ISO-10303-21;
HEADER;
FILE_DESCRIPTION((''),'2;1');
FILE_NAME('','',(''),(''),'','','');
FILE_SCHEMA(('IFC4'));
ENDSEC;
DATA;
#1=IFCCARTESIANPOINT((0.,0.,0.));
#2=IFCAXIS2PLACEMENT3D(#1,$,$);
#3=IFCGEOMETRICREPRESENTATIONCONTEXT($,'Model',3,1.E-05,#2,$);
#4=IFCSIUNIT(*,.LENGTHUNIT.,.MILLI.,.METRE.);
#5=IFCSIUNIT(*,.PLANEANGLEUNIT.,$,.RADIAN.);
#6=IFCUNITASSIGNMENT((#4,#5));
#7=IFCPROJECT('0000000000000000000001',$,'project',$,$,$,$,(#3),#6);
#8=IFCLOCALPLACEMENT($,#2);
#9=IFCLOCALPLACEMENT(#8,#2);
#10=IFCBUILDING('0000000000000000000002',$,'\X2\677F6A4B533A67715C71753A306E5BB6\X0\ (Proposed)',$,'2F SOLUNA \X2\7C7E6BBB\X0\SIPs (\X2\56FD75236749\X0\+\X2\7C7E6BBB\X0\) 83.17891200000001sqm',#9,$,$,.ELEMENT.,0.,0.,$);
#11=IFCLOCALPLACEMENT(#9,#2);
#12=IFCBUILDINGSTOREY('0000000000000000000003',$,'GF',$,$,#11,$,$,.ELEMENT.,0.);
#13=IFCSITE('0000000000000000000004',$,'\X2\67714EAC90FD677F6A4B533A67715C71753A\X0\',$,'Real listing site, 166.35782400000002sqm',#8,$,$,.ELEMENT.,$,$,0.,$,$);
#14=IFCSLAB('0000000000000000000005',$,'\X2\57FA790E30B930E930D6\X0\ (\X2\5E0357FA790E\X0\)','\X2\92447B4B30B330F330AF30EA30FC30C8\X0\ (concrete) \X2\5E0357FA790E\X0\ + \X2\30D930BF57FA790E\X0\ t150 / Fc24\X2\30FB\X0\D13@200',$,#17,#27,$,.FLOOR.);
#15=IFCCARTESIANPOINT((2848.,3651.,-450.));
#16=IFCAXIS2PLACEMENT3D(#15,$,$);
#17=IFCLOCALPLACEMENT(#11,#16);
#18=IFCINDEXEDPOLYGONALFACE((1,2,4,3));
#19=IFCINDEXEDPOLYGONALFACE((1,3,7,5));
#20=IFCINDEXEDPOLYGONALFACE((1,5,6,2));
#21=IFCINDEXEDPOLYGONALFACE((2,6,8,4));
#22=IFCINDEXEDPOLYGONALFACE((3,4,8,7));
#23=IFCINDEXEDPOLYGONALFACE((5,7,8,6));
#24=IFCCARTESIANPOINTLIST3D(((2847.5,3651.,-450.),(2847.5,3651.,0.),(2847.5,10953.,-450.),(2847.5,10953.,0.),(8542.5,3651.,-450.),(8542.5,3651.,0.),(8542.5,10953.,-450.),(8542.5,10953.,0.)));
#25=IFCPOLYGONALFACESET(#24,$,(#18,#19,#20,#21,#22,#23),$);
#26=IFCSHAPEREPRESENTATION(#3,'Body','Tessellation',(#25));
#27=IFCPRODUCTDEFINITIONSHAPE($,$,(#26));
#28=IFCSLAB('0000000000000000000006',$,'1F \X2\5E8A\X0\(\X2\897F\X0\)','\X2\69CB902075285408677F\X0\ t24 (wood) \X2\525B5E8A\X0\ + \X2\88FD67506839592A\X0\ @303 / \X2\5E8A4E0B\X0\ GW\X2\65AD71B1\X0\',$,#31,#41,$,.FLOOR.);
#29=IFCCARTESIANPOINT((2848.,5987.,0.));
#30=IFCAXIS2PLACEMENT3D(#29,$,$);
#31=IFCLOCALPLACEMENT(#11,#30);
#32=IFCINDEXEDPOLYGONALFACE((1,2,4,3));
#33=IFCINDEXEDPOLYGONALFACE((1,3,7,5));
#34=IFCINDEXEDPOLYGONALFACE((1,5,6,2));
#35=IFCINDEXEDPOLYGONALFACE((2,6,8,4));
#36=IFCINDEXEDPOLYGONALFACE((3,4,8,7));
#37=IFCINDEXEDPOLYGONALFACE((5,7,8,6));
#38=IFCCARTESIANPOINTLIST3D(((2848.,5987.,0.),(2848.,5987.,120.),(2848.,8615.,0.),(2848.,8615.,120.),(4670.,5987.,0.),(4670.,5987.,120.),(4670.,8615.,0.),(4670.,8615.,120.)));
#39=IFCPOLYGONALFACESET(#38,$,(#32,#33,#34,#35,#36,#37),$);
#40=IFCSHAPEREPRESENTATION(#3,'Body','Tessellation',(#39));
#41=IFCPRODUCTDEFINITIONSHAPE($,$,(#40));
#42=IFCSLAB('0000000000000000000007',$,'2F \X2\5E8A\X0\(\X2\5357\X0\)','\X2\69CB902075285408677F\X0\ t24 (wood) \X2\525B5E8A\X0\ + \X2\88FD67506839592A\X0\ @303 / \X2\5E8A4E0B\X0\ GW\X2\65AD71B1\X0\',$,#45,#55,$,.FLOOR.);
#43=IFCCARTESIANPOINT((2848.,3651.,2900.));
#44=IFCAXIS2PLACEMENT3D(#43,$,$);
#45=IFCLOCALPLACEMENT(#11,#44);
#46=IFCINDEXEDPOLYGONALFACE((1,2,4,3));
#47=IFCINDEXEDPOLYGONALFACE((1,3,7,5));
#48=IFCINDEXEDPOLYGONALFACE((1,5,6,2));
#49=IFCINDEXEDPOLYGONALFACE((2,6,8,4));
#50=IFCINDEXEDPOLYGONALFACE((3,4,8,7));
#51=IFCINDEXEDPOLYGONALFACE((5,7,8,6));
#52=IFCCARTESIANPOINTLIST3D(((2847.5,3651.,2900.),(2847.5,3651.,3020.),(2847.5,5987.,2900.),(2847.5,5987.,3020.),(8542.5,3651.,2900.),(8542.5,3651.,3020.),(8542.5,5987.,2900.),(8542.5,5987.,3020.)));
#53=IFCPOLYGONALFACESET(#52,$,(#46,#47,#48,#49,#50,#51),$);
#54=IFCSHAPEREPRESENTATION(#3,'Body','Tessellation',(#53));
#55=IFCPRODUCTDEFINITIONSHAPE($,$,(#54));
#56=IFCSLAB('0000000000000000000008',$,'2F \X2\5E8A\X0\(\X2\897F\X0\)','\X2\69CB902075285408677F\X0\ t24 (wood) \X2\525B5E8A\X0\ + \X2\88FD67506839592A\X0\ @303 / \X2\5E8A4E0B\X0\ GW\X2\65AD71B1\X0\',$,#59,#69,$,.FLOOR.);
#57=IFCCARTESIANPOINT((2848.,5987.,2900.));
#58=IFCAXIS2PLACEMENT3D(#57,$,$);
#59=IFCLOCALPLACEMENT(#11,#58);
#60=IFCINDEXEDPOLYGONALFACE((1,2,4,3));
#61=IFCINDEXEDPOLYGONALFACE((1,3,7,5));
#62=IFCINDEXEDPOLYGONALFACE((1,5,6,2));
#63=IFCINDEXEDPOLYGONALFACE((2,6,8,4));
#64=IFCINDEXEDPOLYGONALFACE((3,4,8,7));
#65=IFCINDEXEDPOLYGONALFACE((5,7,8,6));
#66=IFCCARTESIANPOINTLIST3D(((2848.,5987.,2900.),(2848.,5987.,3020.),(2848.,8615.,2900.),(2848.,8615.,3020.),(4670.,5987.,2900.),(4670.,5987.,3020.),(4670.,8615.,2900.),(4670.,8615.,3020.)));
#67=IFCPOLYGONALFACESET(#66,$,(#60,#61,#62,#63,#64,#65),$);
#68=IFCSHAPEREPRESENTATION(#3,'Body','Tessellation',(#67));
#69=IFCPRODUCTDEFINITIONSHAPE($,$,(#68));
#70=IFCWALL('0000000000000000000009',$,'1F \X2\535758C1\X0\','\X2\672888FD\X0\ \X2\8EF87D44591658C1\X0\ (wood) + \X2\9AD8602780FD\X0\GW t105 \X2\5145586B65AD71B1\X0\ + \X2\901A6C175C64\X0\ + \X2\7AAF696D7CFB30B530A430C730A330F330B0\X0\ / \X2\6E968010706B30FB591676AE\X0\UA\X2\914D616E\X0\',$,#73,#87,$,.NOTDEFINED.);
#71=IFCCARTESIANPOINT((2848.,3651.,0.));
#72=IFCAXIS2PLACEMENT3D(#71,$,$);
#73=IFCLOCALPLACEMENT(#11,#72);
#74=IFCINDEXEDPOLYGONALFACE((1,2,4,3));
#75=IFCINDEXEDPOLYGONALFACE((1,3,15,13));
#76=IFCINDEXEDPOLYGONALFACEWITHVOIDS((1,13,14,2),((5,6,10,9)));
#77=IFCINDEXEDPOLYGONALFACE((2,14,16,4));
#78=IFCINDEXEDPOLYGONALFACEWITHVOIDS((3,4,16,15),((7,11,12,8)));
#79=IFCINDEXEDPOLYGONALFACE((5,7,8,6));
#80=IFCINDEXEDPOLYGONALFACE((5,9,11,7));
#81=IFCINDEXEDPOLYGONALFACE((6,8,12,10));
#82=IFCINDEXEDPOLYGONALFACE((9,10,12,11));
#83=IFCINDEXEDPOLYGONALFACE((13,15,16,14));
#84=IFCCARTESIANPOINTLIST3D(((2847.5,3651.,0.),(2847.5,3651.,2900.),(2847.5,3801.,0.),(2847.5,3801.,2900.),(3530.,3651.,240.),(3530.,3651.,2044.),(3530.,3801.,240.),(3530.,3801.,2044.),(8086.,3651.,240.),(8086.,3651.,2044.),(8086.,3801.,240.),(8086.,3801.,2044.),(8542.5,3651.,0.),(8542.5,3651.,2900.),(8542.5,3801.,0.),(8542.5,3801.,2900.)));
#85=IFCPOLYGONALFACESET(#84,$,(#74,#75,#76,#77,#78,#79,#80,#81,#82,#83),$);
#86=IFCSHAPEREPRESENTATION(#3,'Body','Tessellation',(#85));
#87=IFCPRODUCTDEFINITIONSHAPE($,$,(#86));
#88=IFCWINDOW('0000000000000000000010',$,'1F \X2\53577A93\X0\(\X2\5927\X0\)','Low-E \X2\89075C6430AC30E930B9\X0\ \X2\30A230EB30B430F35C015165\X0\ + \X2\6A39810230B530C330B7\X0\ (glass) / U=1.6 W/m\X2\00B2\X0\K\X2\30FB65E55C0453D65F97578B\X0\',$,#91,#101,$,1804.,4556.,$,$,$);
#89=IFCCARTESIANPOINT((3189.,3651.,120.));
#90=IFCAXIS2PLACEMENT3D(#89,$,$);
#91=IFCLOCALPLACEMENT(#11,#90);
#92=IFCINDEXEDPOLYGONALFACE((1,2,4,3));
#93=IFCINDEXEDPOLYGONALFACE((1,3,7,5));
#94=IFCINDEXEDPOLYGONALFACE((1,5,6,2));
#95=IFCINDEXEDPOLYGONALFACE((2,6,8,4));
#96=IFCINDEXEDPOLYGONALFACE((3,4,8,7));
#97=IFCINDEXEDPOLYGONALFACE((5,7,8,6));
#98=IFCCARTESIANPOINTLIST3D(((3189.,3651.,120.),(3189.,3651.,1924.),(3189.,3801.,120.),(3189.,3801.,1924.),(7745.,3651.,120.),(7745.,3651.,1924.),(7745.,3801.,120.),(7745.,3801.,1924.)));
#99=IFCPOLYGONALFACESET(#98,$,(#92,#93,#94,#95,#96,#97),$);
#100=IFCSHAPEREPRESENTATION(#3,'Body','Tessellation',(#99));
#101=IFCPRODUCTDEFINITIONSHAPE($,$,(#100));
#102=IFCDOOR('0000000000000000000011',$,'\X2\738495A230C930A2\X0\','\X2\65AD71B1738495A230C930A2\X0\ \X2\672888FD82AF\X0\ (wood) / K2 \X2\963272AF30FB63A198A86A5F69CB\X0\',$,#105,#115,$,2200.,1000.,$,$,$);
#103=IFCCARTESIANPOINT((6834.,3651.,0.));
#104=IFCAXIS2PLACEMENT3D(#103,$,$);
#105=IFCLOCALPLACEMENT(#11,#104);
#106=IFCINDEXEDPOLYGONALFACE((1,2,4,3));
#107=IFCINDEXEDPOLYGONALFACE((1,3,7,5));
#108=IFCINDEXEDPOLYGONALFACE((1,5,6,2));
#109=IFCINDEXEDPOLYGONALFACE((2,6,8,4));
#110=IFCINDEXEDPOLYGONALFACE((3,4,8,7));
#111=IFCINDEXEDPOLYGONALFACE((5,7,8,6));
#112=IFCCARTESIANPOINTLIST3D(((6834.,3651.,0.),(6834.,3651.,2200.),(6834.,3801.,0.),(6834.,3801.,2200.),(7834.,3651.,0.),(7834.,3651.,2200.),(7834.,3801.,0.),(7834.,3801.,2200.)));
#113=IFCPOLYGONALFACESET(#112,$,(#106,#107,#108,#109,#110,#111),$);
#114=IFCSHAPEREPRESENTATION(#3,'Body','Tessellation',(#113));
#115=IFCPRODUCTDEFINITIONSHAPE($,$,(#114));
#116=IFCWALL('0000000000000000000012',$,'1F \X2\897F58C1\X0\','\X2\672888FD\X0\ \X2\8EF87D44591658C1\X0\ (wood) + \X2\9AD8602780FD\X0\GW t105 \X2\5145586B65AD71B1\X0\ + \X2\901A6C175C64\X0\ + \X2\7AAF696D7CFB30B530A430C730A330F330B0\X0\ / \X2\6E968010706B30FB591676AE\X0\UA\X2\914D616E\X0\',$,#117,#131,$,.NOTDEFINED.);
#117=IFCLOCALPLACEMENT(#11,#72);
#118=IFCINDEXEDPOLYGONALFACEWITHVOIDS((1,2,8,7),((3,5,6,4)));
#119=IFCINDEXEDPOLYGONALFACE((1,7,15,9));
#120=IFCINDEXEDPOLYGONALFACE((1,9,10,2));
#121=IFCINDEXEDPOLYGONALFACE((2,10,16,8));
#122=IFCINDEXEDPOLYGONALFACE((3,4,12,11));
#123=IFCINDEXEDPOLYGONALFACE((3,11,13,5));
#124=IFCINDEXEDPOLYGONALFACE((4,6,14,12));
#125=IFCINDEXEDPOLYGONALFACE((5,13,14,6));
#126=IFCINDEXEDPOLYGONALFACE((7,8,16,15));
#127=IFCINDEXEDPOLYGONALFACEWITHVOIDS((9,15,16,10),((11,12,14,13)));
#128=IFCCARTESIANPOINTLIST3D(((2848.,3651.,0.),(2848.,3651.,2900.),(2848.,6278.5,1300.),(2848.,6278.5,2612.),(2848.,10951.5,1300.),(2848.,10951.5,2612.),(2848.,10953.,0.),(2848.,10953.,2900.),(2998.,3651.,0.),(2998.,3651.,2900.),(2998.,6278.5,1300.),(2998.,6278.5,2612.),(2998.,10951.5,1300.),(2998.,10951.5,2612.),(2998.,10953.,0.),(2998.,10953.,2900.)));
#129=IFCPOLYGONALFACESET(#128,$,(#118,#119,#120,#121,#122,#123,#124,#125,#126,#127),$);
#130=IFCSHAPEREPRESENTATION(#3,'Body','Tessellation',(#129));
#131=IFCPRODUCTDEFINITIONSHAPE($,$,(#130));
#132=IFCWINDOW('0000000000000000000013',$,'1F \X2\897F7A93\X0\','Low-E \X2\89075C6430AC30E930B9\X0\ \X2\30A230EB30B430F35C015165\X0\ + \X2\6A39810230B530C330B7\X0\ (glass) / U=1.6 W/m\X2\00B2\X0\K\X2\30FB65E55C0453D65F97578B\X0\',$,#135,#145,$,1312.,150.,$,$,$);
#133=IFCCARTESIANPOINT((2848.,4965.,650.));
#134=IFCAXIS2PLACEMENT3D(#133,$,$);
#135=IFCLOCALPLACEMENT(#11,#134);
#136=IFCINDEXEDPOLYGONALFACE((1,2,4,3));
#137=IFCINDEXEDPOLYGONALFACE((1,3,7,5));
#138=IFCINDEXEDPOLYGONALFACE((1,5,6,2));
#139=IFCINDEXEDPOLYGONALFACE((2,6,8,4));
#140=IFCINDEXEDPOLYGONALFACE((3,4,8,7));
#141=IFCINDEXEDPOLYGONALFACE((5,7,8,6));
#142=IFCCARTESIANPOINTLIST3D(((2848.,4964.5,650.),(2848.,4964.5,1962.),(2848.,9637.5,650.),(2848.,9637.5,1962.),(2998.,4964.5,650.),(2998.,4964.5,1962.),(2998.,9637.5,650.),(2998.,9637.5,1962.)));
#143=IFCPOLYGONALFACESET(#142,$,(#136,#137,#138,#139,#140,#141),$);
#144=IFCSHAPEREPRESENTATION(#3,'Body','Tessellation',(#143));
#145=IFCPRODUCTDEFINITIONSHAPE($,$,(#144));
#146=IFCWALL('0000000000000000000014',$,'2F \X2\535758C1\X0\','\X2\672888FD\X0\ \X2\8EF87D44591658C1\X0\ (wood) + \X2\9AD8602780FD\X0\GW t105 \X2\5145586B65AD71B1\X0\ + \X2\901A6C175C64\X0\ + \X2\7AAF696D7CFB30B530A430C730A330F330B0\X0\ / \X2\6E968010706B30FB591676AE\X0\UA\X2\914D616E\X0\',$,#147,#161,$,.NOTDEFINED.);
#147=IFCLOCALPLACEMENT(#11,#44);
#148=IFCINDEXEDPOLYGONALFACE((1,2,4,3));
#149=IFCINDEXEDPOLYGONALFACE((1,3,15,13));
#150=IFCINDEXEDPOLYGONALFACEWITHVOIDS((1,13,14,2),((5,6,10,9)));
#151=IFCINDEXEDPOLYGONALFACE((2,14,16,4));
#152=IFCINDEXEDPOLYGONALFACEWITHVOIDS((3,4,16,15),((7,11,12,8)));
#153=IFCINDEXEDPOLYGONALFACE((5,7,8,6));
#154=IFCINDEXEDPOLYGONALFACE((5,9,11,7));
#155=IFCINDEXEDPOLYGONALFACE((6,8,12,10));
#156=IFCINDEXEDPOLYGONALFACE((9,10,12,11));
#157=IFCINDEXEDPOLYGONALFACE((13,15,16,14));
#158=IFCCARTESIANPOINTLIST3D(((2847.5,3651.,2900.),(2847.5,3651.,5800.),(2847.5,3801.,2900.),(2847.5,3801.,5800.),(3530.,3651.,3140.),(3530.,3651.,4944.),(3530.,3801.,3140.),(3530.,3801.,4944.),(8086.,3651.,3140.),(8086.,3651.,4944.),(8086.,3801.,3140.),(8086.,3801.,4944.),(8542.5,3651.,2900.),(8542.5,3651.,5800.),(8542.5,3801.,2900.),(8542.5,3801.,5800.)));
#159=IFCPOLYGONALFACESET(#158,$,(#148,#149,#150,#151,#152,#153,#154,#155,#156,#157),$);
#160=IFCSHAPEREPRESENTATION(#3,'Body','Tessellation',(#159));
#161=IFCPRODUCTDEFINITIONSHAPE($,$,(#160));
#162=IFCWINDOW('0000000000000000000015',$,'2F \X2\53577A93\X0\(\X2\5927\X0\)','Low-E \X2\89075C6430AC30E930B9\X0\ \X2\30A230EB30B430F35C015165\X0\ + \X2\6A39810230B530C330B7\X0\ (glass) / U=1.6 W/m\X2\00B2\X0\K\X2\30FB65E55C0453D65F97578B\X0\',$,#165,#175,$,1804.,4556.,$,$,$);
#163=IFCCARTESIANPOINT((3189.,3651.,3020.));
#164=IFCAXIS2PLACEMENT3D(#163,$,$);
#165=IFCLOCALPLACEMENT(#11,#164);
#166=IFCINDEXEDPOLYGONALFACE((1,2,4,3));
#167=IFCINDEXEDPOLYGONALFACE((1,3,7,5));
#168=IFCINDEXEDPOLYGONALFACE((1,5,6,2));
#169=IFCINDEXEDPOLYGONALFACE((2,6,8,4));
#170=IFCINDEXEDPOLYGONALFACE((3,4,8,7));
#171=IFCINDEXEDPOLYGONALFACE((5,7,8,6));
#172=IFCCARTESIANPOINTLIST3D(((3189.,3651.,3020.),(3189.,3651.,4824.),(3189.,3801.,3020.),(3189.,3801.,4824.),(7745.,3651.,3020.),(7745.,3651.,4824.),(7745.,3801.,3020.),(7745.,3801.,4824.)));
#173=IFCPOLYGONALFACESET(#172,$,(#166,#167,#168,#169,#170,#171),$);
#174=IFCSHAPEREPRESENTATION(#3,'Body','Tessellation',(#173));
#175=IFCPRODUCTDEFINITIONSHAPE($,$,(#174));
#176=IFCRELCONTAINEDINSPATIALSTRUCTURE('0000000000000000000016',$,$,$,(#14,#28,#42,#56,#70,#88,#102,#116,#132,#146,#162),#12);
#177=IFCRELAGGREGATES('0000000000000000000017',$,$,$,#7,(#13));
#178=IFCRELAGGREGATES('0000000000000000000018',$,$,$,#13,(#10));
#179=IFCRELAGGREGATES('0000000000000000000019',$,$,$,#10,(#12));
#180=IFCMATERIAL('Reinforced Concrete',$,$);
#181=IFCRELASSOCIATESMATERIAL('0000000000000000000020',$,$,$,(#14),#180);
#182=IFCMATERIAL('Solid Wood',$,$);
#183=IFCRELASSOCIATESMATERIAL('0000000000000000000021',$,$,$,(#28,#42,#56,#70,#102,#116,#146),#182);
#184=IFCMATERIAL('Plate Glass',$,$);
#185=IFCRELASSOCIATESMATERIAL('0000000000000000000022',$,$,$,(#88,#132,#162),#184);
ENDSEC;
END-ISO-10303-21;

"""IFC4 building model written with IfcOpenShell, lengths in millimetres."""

from ifc_helpers import new_model, si_unit, frame, frame_2d, origin, place, context, project, spatial, rectangle, extrude, material, element, fill, save


model = new_model("IFC4")

# Units and contexts
model_context = context("Model", 3, precision=1e-05, world=origin())
ifc_project = project(units=[si_unit("LENGTHUNIT", "METRE", prefix="MILLI"), si_unit("PLANEANGLEUNIT", "RADIAN")], contexts=[model_context])

# Site, building, storey
site_placement = place(None, origin())
site = spatial("IfcSite", under=ifc_project, at=site_placement, Name="東京都板橋区東山町", ObjectType="Real listing site, 166.35782400000002sqm", CompositionType="ELEMENT", RefElevation=0.0)
building_placement = place(site_placement, origin())
building = spatial("IfcBuilding", under=site, at=building_placement, Name="板橋区東山町の家 (Proposed)", ObjectType="2F SOLUNA 籾殻SIPs (国産杉+籾殻) 83.17891200000001sqm", CompositionType="ELEMENT", ElevationOfRefHeight=0.0, ElevationOfTerrain=0.0)
storey_placement = place(building_placement, origin())
storey = spatial("IfcBuildingStorey", under=building, at=storey_placement, Name="GF", CompositionType="ELEMENT", Elevation=0.0)

# Slabs
ifc_material_1 = material(Name="Reinforced Concrete")
slab_1_placement = place(storey_placement, frame((2848.0, 3651.0, -450.0)))
element("IfcSlab", 1, at=slab_1_placement, inside=storey, material=ifc_material_1, Name="基礎スラブ (布基礎)", Description="鉄筋コンクリート (concrete) 布基礎 + ベタ基礎 t150 / Fc24・D13@200", PredefinedType="FLOOR", context=model_context, shape_type="SweptSolid", body=[
    extrude(rectangle(XDim=5695.0, YDim=7302.0, at=frame_2d((2847.0, 3651.0))), frame((2848.0, 3651.0, -450.0)), (0.0, 0.0, 1.0), 450.0),
])
ifc_material_2 = material(Name="Solid Wood")
slab_2_placement = place(storey_placement, frame((2848.0, 5987.0, 0.0)))
element("IfcSlab", 2, at=slab_2_placement, inside=storey, material=ifc_material_2, Name="1F 床(西)", Description="構造用合板 t24 (wood) 剛床 + 製材根太 @303 / 床下 GW断熱", PredefinedType="FLOOR", context=model_context, shape_type="SweptSolid", body=[
    extrude(rectangle(XDim=1822.0, YDim=2628.0, at=frame_2d((911.0, 1314.0))), frame((2848.0, 5987.0, 0.0)), (0.0, 0.0, 1.0), 120.0),
])
slab_3_placement = place(storey_placement, frame((2848.0, 3651.0, 2900.0)))
element("IfcSlab", 3, at=slab_3_placement, inside=storey, material=ifc_material_2, Name="2F 床(南)", Description="構造用合板 t24 (wood) 剛床 + 製材根太 @303 / 床下 GW断熱", PredefinedType="FLOOR", context=model_context, shape_type="SweptSolid", body=[
    extrude(rectangle(XDim=5695.0, YDim=2336.0, at=frame_2d((2847.0, 1168.0))), frame((2848.0, 3651.0, 2900.0)), (0.0, 0.0, 1.0), 120.0),
])
slab_4_placement = place(storey_placement, frame((2848.0, 5987.0, 2900.0)))
element("IfcSlab", 4, at=slab_4_placement, inside=storey, material=ifc_material_2, Name="2F 床(西)", Description="構造用合板 t24 (wood) 剛床 + 製材根太 @303 / 床下 GW断熱", PredefinedType="FLOOR", context=model_context, shape_type="SweptSolid", body=[
    extrude(rectangle(XDim=1822.0, YDim=2628.0, at=frame_2d((911.0, 1314.0))), frame((2848.0, 5987.0, 2900.0)), (0.0, 0.0, 1.0), 120.0),
])

# Wall, openings, window, door
wall_1_placement = place(storey_placement, frame((2848.0, 3651.0, 0.0)))
wall_1 = element("IfcWall", 5, at=wall_1_placement, inside=storey, material=ifc_material_2, Name="1F 南壁", Description="木製 軸組外壁 (wood) + 高性能GW t105 充填断熱 + 通気層 + 窯業系サイディング / 準耐火・外皮UA配慮", PredefinedType="NOTDEFINED", context=model_context, shape_type="SweptSolid", body=[
    extrude(rectangle(XDim=5695.0, YDim=150.0, at=frame_2d((2847.0, 75.0))), frame((2848.0, 3651.0, 0.0)), (0.0, 0.0, 1.0), 2900.0),
])
opening_1_placement = place(storey_placement, frame((3189.0, 3651.0, 120.0)))
opening_1 = element("IfcOpeningElement", 6, at=opening_1_placement, cuts=wall_1, PredefinedType="NOTDEFINED", context=model_context, shape_type="SweptSolid", body=[
    extrude(rectangle(XDim=4556.0, YDim=150.0, at=frame_2d((2278.0, 75.0))), frame((3189.0, 3651.0, 120.0)), (0.0, 0.0, 1.0), 1804.0),
])
opening_2_placement = place(storey_placement, frame((6834.0, 3651.0, 0.0)))
opening_2 = element("IfcOpeningElement", 7, at=opening_2_placement, cuts=wall_1, PredefinedType="NOTDEFINED", context=model_context, shape_type="SweptSolid", body=[
    extrude(rectangle(XDim=1000.0, YDim=150.0, at=frame_2d((500.0, 75.0))), frame((6834.0, 3651.0, 0.0)), (0.0, 0.0, 1.0), 2200.0),
])
ifc_material_3 = material(Name="Plate Glass")
window_1_placement = place(storey_placement, frame((3189.0, 3651.0, 120.0)))
window_1 = element("IfcWindow", 8, at=window_1_placement, inside=storey, material=ifc_material_3, Name="1F 南窓(大)", Description="Low-E 複層ガラス アルゴン封入 + 樹脂サッシ (glass) / U=1.6 W/m²K・日射取得型", OverallHeight=1804.0, OverallWidth=4556.0, context=model_context, shape_type="SweptSolid", body=[
    extrude(rectangle(XDim=4556.0, YDim=150.0, at=frame_2d((2278.0, 75.0))), frame((3189.0, 3651.0, 120.0)), (0.0, 0.0, 1.0), 1804.0),
])
fill(opening_1, window_1)
door_placement = place(storey_placement, frame((6834.0, 3651.0, 0.0)))
door = element("IfcDoor", 9, at=door_placement, inside=storey, material=ifc_material_2, Name="玄関ドア", Description="断熱玄関ドア 木製芯 (wood) / K2 防犯・採風機構", OverallHeight=2200.0, OverallWidth=1000.0, context=model_context, shape_type="SweptSolid", body=[
    extrude(rectangle(XDim=1000.0, YDim=150.0, at=frame_2d((500.0, 75.0))), frame((6834.0, 3651.0, 0.0)), (0.0, 0.0, 1.0), 2200.0),
])
fill(opening_2, door)

# Walls, openings, windows
wall_2_placement = place(storey_placement, frame((2848.0, 3651.0, 0.0)))
wall_2 = element("IfcWall", 10, at=wall_2_placement, inside=storey, material=ifc_material_2, Name="1F 西壁", Description="木製 軸組外壁 (wood) + 高性能GW t105 充填断熱 + 通気層 + 窯業系サイディング / 準耐火・外皮UA配慮", PredefinedType="NOTDEFINED", context=model_context, shape_type="SweptSolid", body=[
    extrude(rectangle(XDim=150.0, YDim=7302.0, at=frame_2d((75.0, 3651.0))), frame((2848.0, 3651.0, 0.0)), (0.0, 0.0, 1.0), 2900.0),
])
opening_3_placement = place(storey_placement, frame((2848.0, 4965.0, 650.0)))
opening_3 = element("IfcOpeningElement", 11, at=opening_3_placement, cuts=wall_2, PredefinedType="NOTDEFINED", context=model_context, shape_type="SweptSolid", body=[
    extrude(rectangle(XDim=150.0, YDim=4673.0, at=frame_2d((75.0, 2336.0))), frame((2848.0, 4965.0, 650.0)), (0.0, 0.0, 1.0), 1312.0),
])
window_2_placement = place(storey_placement, frame((2848.0, 4965.0, 650.0)))
window_2 = element("IfcWindow", 12, at=window_2_placement, inside=storey, material=ifc_material_3, Name="1F 西窓", Description="Low-E 複層ガラス アルゴン封入 + 樹脂サッシ (glass) / U=1.6 W/m²K・日射取得型", OverallHeight=1312.0, OverallWidth=150.0, context=model_context, shape_type="SweptSolid", body=[
    extrude(rectangle(XDim=150.0, YDim=4673.0, at=frame_2d((75.0, 2336.0))), frame((2848.0, 4965.0, 650.0)), (0.0, 0.0, 1.0), 1312.0),
])
fill(opening_3, window_2)
wall_3_placement = place(storey_placement, frame((2848.0, 3651.0, 2900.0)))
wall_3 = element("IfcWall", 13, at=wall_3_placement, inside=storey, material=ifc_material_2, Name="2F 南壁", Description="木製 軸組外壁 (wood) + 高性能GW t105 充填断熱 + 通気層 + 窯業系サイディング / 準耐火・外皮UA配慮", PredefinedType="NOTDEFINED", context=model_context, shape_type="SweptSolid", body=[
    extrude(rectangle(XDim=5695.0, YDim=150.0, at=frame_2d((2847.0, 75.0))), frame((2848.0, 3651.0, 2900.0)), (0.0, 0.0, 1.0), 2900.0),
])
opening_4_placement = place(storey_placement, frame((3189.0, 3651.0, 3020.0)))
opening_4 = element("IfcOpeningElement", 14, at=opening_4_placement, cuts=wall_3, PredefinedType="NOTDEFINED", context=model_context, shape_type="SweptSolid", body=[
    extrude(rectangle(XDim=4556.0, YDim=150.0, at=frame_2d((2278.0, 75.0))), frame((3189.0, 3651.0, 3020.0)), (0.0, 0.0, 1.0), 1804.0),
])
window_3_placement = place(storey_placement, frame((3189.0, 3651.0, 3020.0)))
window_3 = element("IfcWindow", 15, at=window_3_placement, inside=storey, material=ifc_material_3, Name="2F 南窓(大)", Description="Low-E 複層ガラス アルゴン封入 + 樹脂サッシ (glass) / U=1.6 W/m²K・日射取得型", OverallHeight=1804.0, OverallWidth=4556.0, context=model_context, shape_type="SweptSolid", body=[
    extrude(rectangle(XDim=4556.0, YDim=150.0, at=frame_2d((2278.0, 75.0))), frame((3189.0, 3651.0, 3020.0)), (0.0, 0.0, 1.0), 1804.0),
])
fill(opening_4, window_3)

save(model, "model.ifc")
